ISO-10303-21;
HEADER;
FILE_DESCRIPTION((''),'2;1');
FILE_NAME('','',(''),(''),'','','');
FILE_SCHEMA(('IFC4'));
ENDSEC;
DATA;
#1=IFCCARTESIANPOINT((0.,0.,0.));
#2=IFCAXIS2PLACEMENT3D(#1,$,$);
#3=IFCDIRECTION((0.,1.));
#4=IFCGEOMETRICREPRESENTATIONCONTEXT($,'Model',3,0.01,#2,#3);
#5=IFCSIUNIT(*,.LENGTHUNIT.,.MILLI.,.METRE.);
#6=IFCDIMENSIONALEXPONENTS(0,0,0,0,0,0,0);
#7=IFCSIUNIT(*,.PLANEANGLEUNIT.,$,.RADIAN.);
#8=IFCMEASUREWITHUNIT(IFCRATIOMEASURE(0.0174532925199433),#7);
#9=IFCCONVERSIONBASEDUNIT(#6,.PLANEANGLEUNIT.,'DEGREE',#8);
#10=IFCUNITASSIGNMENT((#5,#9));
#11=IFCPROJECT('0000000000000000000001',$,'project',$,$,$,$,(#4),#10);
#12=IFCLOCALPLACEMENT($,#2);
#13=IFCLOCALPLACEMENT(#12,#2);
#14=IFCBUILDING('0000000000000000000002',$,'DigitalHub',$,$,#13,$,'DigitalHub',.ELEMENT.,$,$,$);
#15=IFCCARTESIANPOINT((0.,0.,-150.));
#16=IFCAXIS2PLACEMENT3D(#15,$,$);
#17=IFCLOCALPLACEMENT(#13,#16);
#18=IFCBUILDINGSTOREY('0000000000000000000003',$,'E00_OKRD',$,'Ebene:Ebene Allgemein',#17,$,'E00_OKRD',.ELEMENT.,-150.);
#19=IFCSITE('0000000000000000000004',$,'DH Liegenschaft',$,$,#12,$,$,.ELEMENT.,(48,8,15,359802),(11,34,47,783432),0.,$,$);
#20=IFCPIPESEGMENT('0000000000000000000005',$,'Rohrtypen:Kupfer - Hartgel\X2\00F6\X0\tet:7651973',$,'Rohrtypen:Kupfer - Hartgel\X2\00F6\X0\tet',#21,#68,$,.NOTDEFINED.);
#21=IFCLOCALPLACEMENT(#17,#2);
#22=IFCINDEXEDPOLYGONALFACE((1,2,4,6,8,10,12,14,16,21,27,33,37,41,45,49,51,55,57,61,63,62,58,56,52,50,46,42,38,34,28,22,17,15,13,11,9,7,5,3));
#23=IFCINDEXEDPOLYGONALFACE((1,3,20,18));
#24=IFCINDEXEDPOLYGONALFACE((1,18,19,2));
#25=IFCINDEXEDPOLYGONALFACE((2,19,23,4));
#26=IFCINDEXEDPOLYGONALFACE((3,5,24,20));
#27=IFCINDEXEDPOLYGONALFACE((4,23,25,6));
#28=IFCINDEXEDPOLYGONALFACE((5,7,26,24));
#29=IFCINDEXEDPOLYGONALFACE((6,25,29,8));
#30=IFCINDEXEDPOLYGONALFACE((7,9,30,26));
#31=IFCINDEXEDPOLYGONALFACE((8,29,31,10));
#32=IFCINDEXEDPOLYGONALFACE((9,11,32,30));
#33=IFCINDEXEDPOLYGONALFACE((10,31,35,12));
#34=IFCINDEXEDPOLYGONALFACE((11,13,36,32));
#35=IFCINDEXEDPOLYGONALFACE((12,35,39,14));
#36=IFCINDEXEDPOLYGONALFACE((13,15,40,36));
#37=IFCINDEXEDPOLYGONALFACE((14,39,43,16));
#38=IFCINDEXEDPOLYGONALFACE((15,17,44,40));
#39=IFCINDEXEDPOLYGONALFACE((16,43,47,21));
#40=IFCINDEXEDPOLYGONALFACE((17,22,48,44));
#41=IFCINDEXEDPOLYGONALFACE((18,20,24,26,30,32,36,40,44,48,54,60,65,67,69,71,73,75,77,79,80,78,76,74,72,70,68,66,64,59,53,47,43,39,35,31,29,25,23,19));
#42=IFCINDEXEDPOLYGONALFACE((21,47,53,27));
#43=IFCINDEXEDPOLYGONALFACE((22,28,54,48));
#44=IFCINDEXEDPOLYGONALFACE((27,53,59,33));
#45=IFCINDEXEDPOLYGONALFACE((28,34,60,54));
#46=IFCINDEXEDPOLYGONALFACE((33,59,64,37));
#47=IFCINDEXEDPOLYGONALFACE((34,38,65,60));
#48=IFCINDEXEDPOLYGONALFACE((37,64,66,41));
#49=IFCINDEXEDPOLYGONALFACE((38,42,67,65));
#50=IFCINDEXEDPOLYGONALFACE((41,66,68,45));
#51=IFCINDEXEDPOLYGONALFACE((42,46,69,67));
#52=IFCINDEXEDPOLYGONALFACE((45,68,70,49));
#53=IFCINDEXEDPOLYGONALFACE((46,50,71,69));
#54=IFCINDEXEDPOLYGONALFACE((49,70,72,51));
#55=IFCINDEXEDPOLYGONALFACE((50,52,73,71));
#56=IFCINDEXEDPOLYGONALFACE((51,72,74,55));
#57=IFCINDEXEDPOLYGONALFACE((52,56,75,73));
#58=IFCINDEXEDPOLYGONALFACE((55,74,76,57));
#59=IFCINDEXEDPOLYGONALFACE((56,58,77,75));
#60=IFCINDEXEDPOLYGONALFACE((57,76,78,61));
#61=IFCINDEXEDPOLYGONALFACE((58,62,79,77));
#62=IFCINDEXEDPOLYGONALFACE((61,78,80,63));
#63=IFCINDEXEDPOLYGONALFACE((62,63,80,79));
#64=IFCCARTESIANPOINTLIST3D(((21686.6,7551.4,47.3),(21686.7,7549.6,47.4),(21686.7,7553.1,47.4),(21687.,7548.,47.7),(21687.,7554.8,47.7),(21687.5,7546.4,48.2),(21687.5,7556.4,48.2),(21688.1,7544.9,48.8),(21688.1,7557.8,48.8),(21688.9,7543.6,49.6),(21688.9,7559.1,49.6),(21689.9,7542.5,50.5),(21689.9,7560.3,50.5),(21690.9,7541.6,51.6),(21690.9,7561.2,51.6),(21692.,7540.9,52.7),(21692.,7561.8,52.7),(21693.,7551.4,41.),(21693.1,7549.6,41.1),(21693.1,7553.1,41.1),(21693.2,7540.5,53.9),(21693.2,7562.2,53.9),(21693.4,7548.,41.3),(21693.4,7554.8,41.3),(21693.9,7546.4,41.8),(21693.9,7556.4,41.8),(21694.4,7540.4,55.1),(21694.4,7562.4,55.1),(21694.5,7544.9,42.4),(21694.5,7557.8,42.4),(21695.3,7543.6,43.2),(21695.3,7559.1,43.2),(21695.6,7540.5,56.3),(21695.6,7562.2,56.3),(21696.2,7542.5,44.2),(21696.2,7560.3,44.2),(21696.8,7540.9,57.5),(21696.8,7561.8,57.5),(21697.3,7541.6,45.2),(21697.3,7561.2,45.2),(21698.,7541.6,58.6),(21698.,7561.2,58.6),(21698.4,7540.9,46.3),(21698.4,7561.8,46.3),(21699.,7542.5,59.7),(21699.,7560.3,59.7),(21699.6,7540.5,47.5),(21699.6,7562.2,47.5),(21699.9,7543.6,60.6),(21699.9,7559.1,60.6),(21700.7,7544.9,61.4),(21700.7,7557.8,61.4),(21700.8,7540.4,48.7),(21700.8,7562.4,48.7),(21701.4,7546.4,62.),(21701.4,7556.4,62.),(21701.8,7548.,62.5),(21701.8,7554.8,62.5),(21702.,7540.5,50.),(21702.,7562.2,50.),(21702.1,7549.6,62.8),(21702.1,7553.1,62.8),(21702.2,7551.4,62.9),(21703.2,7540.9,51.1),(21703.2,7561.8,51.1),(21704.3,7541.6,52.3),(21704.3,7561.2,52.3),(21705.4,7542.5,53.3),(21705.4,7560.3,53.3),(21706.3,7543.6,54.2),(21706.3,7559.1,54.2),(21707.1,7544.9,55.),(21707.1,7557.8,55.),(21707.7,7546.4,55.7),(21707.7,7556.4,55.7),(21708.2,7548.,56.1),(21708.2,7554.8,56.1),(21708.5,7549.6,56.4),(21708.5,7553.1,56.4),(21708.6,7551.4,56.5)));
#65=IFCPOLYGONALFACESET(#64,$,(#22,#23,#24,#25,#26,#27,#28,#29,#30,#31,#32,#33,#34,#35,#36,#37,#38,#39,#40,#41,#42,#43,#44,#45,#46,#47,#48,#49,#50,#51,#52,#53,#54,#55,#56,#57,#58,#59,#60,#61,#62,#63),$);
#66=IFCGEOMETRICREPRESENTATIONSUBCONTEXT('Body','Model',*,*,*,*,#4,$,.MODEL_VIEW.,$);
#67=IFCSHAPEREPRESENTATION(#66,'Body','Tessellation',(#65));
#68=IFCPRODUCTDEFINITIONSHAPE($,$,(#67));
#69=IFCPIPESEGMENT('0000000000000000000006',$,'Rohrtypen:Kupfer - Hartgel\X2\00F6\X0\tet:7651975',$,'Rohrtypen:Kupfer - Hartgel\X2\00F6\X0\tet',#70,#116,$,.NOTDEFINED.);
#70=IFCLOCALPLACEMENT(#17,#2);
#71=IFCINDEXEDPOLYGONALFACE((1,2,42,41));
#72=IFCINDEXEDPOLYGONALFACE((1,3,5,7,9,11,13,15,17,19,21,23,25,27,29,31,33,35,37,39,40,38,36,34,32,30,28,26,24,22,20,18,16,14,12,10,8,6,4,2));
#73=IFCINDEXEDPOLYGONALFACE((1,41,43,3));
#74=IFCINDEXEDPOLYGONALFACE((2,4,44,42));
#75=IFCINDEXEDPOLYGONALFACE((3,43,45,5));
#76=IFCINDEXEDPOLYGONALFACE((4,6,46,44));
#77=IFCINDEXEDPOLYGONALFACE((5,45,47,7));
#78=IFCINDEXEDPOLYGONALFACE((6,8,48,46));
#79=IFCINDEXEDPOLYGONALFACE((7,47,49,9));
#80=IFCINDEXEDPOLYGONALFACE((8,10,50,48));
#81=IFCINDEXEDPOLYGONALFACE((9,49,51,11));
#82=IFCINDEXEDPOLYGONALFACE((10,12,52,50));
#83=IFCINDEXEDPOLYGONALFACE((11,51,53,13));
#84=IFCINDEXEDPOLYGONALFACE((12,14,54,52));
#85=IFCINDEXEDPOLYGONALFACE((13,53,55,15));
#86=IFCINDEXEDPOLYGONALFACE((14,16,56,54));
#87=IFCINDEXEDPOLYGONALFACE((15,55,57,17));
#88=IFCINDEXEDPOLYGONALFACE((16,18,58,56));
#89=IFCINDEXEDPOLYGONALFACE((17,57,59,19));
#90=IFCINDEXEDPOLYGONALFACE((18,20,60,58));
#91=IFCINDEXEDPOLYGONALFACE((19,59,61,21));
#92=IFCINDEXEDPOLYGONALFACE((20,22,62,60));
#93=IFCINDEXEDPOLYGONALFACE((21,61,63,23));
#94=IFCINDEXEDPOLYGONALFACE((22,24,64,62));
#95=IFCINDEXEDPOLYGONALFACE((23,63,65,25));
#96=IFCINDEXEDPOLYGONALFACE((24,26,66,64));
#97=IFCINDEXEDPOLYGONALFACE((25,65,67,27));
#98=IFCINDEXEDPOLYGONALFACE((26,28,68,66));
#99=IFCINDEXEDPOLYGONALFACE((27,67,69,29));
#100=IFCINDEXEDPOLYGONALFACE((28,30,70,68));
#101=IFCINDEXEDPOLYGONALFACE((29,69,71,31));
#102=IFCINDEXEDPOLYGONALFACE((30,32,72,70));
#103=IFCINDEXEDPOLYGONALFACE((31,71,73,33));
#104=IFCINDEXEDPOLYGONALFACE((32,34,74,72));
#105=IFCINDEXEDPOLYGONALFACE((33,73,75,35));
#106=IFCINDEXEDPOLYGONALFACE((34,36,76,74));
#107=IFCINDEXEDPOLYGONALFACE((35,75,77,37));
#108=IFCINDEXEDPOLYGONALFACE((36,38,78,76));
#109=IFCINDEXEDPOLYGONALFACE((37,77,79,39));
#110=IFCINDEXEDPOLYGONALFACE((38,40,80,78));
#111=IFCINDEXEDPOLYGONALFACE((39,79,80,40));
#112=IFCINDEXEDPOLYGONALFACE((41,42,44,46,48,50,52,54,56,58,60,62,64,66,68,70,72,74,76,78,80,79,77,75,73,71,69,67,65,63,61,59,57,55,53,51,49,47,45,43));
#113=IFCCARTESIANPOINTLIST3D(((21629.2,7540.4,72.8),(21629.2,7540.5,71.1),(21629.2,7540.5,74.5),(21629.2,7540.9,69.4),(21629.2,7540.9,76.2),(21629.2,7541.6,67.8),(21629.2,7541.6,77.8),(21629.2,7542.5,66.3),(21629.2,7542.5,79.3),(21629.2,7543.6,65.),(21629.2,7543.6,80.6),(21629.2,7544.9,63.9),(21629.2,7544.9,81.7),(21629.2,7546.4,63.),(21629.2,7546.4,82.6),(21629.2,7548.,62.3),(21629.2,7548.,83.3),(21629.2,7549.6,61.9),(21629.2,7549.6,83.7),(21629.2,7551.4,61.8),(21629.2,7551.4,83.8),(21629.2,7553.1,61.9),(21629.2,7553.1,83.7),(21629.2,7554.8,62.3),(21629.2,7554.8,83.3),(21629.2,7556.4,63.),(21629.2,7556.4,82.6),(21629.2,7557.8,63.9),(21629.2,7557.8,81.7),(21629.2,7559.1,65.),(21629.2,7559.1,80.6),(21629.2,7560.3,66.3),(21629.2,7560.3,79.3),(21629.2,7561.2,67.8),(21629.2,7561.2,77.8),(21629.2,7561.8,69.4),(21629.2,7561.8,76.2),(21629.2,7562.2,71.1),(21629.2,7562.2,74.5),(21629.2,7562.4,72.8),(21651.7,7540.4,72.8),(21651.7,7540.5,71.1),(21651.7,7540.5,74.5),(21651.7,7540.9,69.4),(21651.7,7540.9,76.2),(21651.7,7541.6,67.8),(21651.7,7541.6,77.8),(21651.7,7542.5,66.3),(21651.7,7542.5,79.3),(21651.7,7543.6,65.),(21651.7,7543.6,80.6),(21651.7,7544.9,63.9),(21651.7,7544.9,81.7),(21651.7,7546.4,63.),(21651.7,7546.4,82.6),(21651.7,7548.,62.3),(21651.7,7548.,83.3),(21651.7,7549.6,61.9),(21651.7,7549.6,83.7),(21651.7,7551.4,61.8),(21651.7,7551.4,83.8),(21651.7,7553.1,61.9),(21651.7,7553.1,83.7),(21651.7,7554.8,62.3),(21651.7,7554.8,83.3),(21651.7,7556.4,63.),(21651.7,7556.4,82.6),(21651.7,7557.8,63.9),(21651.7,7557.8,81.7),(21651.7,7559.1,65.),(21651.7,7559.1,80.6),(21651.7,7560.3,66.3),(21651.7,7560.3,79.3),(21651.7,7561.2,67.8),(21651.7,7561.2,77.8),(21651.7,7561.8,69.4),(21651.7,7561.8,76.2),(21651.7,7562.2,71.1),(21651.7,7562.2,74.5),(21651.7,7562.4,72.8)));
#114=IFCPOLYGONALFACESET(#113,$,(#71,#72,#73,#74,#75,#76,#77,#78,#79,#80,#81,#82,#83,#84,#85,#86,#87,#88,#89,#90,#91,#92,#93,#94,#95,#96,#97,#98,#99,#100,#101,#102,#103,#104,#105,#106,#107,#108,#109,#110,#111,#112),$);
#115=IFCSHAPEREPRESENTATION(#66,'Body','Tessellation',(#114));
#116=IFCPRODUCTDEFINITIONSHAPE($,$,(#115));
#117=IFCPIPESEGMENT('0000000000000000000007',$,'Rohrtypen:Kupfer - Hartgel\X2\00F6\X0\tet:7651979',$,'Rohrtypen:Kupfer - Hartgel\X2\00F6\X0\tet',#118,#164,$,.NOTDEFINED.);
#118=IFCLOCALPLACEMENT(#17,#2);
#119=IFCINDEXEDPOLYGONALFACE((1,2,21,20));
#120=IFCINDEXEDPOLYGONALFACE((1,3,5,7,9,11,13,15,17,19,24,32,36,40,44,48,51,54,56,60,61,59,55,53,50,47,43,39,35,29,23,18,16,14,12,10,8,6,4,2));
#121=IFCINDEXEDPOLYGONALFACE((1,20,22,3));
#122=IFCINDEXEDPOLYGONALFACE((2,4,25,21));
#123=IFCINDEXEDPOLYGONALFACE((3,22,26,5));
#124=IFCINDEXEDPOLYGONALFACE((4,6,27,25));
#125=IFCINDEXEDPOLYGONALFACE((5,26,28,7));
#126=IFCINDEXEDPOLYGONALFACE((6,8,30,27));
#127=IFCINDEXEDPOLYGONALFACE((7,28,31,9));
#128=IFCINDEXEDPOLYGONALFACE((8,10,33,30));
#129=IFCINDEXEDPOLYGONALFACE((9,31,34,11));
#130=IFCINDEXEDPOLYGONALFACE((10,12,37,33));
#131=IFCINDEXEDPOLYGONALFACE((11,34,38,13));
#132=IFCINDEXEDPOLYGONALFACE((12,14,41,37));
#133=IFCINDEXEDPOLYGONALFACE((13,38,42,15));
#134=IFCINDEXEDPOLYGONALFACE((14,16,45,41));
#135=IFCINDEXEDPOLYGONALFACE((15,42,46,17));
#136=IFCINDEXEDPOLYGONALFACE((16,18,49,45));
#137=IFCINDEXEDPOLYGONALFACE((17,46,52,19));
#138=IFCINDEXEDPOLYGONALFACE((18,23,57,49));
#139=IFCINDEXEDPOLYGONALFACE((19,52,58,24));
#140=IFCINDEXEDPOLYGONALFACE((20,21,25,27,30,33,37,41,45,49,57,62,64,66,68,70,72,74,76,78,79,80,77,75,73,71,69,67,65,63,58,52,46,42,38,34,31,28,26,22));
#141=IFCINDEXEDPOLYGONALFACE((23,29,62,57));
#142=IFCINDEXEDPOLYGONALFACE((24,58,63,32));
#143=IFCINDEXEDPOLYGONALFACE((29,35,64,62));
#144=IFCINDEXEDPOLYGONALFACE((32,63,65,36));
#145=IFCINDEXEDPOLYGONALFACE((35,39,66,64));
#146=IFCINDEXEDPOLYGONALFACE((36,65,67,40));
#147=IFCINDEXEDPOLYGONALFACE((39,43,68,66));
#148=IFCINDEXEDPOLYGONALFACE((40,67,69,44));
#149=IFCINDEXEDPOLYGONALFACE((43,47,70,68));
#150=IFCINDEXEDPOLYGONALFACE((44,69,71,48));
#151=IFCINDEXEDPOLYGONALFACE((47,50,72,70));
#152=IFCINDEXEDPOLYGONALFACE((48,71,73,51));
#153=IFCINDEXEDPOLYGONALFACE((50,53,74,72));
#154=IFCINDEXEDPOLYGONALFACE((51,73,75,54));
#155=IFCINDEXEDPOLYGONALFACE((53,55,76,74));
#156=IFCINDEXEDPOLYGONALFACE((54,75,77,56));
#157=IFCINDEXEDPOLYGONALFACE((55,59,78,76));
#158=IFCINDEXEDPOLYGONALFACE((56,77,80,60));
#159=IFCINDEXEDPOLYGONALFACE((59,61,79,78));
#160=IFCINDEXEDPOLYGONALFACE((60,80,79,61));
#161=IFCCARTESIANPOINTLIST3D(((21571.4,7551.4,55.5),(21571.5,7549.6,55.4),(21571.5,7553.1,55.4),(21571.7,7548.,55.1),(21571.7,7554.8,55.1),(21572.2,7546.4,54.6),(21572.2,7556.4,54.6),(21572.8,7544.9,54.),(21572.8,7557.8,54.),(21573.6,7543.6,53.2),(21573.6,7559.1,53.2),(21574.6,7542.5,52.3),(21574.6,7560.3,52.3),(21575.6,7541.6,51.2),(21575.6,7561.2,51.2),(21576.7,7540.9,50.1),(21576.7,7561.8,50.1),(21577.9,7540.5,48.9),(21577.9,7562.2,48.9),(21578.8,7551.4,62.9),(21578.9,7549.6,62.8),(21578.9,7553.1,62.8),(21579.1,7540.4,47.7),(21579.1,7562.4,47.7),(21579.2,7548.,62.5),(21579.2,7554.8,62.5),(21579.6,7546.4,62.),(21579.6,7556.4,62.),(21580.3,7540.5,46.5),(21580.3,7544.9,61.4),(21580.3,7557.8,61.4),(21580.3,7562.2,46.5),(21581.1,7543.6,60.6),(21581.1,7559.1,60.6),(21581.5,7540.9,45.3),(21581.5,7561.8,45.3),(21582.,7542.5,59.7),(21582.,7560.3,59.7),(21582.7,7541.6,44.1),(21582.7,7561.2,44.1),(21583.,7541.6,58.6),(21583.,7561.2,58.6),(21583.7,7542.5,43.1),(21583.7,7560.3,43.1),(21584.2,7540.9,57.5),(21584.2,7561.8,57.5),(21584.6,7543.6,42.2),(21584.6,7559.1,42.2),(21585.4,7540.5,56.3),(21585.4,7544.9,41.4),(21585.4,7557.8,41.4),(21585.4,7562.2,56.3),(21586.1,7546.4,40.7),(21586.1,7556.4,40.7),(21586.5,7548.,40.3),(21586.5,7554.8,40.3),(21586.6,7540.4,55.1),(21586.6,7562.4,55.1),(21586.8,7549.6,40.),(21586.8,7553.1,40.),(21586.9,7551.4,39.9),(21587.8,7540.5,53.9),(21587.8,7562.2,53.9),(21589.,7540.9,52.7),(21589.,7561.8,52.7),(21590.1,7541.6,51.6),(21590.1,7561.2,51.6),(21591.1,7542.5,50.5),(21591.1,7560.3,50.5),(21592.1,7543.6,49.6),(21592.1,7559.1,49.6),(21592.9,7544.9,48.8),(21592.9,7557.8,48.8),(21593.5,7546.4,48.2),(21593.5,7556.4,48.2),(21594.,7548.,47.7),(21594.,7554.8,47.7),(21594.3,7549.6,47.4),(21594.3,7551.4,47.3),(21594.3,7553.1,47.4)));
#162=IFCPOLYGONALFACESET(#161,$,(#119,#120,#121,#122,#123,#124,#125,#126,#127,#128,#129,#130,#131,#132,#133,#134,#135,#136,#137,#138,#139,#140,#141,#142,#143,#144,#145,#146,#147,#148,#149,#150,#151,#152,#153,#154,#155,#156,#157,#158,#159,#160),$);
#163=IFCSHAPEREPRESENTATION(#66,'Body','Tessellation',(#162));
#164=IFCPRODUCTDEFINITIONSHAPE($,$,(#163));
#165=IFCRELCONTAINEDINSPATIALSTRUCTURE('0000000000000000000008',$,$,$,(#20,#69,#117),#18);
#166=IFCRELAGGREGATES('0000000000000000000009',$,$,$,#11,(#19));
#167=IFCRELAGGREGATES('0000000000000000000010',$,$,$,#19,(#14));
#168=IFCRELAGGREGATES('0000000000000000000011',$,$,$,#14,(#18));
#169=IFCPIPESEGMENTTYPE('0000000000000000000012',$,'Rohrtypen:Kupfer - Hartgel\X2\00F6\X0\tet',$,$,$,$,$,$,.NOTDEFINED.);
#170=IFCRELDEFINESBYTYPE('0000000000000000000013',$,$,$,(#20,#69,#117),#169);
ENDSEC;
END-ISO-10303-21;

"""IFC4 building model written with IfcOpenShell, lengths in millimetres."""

from ifc_helpers import new_model, entity, si_unit, converted_unit, direction, frame, origin, place, context, subcontext, project, spatial, indexed_curve, outline, extrude, type_object, element, save


model = new_model("IFC4")

# Units and contexts
model_context = context("Model", 3, precision=0.01, world=origin(), true_north=direction((0.0, 1.0)))
body_context = subcontext(model_context, "Body", "Model", "MODEL_VIEW")
ifc_project = project(units=[si_unit("LENGTHUNIT", "METRE", prefix="MILLI"), converted_unit("PLANEANGLEUNIT", "DEGREE", entity("IfcRatioMeasure", 0.0174532925199433), si_unit("PLANEANGLEUNIT", "RADIAN"), dimensions=[0, 0, 0, 0, 0, 0, 0])], contexts=[model_context])

# Site, building, storey
site_placement = place(None, origin())
site = spatial("IfcSite", under=ifc_project, at=site_placement, Name="DH Liegenschaft", CompositionType="ELEMENT", RefLatitude=(48, 8, 15, 359802), RefLongitude=(11, 34, 47, 783432), RefElevation=0.0)
building_placement = place(site_placement, origin())
building = spatial("IfcBuilding", under=site, at=building_placement, Name="DigitalHub", LongName="DigitalHub", CompositionType="ELEMENT")
storey_placement = place(building_placement, frame((0.0, 0.0, -150.0)))
storey = spatial("IfcBuildingStorey", under=building, at=storey_placement, Name="E00_OKRD", ObjectType="Ebene:Ebene Allgemein", LongName="E00_OKRD", CompositionType="ELEMENT", Elevation=-150.0)

# Pipe segments
pipe_segment_type = type_object("IfcPipeSegmentType", Name="Rohrtypen:Kupfer - Hartgelötet", PredefinedType="NOTDEFINED")
pipe_segment_1_placement = place(storey_placement, frame((21685.1, 7538.8, 39.4)))
element("IfcPipeSegment", 1, at=pipe_segment_1_placement, inside=storey, type_object=pipe_segment_type, Name="Rohrtypen:Kupfer - Hartgelötet:7651973", ObjectType="Rohrtypen:Kupfer - Hartgelötet", PredefinedType="NOTDEFINED", context=body_context, shape_type="SweptSolid", body=[
    extrude(outline(indexed_curve([(11.0, 0.0), (10.9, 1.7), (10.5, 3.4), (9.8, 5.0), (8.9, 6.5), (7.8, 7.8), (6.5, 8.9), (5.0, 9.8), (3.4, 10.5), (1.7, 10.9), (0.0, 11.0), (-1.7, 10.9), (-3.4, 10.5), (-5.0, 9.8), (-6.5, 8.9), (-7.8, 7.8), (-8.9, 6.5), (-9.8, 5.0), (-10.5, 3.4), (-10.9, 1.7), (-11.0, 0.0), (-10.9, -1.7), (-10.5, -3.4), (-9.8, -5.0), (-8.9, -6.5), (-7.8, -7.8), (-6.5, -8.9), (-5.0, -9.8), (-3.4, -10.5), (-1.7, -10.9), (0.0, -11.0), (1.7, -10.9), (3.4, -10.5), (5.0, -9.8), (6.5, -8.9), (7.8, -7.8), (8.9, -6.5), (9.8, -5.0), (10.5, -3.4), (10.9, -1.7), (11.0, 0.0)], self_intersect=False)), frame((15.7, 12.6, 9.4), z_axis=(-0.707107, 0.0, 0.707107), x_axis=(0.0, -1.0, 0.0)), (0.0, 0.0, 1.0), 9.0),
])
pipe_segment_2_placement = place(storey_placement, frame((21629.2, 7538.8, 60.2)))
element("IfcPipeSegment", 2, at=pipe_segment_2_placement, inside=storey, type_object=pipe_segment_type, Name="Rohrtypen:Kupfer - Hartgelötet:7651975", ObjectType="Rohrtypen:Kupfer - Hartgelötet", PredefinedType="NOTDEFINED", context=body_context, shape_type="SweptSolid", body=[
    extrude(outline(indexed_curve([(11.0, 0.0), (10.9, 1.7), (10.5, 3.4), (9.8, 5.0), (8.9, 6.5), (7.8, 7.8), (6.5, 8.9), (5.0, 9.8), (3.4, 10.5), (1.7, 10.9), (0.0, 11.0), (-1.7, 10.9), (-3.4, 10.5), (-5.0, 9.8), (-6.5, 8.9), (-7.8, 7.8), (-8.9, 6.5), (-9.8, 5.0), (-10.5, 3.4), (-10.9, 1.7), (-11.0, 0.0), (-10.9, -1.7), (-10.5, -3.4), (-9.8, -5.0), (-8.9, -6.5), (-7.8, -7.8), (-6.5, -8.9), (-5.0, -9.8), (-3.4, -10.5), (-1.7, -10.9), (0.0, -11.0), (1.7, -10.9), (3.4, -10.5), (5.0, -9.8), (6.5, -8.9), (7.8, -7.8), (8.9, -6.5), (9.8, -5.0), (10.5, -3.4), (10.9, -1.7), (11.0, 0.0)], self_intersect=False)), frame((0.0, 12.6, 12.6), z_axis=(1.0, 0.0, 0.0), x_axis=(0.0, 1.0, 0.0)), (0.0, 0.0, 1.0), 22.5),
])
pipe_segment_3_placement = place(storey_placement, frame((21569.8, 7538.8, 38.3)))
element("IfcPipeSegment", 3, at=pipe_segment_3_placement, inside=storey, type_object=pipe_segment_type, Name="Rohrtypen:Kupfer - Hartgelötet:7651979", ObjectType="Rohrtypen:Kupfer - Hartgelötet", PredefinedType="NOTDEFINED", context=body_context, shape_type="SweptSolid", body=[
    extrude(outline(indexed_curve([(11.0, 0.0), (10.9, 1.7), (10.5, 3.4), (9.8, 5.0), (8.9, 6.5), (7.8, 7.8), (6.5, 8.9), (5.0, 9.8), (3.4, 10.5), (1.7, 10.9), (0.0, 11.0), (-1.7, 10.9), (-3.4, 10.5), (-5.0, 9.8), (-6.5, 8.9), (-7.8, 7.8), (-8.9, 6.5), (-9.8, 5.0), (-10.5, 3.4), (-10.9, 1.7), (-11.0, 0.0), (-10.9, -1.7), (-10.5, -3.4), (-9.8, -5.0), (-8.9, -6.5), (-7.8, -7.8), (-6.5, -8.9), (-5.0, -9.8), (-3.4, -10.5), (-1.7, -10.9), (0.0, -11.0), (1.7, -10.9), (3.4, -10.5), (5.0, -9.8), (6.5, -8.9), (7.8, -7.8), (8.9, -6.5), (9.8, -5.0), (10.5, -3.4), (10.9, -1.7), (11.0, 0.0)], self_intersect=False)), frame((9.4, 12.6, 9.4), z_axis=(0.707107, 0.0, 0.707107), x_axis=(0.0, 1.0, 0.0)), (0.0, 0.0, 1.0), 10.5),
])

save(model, "model.ifc")
